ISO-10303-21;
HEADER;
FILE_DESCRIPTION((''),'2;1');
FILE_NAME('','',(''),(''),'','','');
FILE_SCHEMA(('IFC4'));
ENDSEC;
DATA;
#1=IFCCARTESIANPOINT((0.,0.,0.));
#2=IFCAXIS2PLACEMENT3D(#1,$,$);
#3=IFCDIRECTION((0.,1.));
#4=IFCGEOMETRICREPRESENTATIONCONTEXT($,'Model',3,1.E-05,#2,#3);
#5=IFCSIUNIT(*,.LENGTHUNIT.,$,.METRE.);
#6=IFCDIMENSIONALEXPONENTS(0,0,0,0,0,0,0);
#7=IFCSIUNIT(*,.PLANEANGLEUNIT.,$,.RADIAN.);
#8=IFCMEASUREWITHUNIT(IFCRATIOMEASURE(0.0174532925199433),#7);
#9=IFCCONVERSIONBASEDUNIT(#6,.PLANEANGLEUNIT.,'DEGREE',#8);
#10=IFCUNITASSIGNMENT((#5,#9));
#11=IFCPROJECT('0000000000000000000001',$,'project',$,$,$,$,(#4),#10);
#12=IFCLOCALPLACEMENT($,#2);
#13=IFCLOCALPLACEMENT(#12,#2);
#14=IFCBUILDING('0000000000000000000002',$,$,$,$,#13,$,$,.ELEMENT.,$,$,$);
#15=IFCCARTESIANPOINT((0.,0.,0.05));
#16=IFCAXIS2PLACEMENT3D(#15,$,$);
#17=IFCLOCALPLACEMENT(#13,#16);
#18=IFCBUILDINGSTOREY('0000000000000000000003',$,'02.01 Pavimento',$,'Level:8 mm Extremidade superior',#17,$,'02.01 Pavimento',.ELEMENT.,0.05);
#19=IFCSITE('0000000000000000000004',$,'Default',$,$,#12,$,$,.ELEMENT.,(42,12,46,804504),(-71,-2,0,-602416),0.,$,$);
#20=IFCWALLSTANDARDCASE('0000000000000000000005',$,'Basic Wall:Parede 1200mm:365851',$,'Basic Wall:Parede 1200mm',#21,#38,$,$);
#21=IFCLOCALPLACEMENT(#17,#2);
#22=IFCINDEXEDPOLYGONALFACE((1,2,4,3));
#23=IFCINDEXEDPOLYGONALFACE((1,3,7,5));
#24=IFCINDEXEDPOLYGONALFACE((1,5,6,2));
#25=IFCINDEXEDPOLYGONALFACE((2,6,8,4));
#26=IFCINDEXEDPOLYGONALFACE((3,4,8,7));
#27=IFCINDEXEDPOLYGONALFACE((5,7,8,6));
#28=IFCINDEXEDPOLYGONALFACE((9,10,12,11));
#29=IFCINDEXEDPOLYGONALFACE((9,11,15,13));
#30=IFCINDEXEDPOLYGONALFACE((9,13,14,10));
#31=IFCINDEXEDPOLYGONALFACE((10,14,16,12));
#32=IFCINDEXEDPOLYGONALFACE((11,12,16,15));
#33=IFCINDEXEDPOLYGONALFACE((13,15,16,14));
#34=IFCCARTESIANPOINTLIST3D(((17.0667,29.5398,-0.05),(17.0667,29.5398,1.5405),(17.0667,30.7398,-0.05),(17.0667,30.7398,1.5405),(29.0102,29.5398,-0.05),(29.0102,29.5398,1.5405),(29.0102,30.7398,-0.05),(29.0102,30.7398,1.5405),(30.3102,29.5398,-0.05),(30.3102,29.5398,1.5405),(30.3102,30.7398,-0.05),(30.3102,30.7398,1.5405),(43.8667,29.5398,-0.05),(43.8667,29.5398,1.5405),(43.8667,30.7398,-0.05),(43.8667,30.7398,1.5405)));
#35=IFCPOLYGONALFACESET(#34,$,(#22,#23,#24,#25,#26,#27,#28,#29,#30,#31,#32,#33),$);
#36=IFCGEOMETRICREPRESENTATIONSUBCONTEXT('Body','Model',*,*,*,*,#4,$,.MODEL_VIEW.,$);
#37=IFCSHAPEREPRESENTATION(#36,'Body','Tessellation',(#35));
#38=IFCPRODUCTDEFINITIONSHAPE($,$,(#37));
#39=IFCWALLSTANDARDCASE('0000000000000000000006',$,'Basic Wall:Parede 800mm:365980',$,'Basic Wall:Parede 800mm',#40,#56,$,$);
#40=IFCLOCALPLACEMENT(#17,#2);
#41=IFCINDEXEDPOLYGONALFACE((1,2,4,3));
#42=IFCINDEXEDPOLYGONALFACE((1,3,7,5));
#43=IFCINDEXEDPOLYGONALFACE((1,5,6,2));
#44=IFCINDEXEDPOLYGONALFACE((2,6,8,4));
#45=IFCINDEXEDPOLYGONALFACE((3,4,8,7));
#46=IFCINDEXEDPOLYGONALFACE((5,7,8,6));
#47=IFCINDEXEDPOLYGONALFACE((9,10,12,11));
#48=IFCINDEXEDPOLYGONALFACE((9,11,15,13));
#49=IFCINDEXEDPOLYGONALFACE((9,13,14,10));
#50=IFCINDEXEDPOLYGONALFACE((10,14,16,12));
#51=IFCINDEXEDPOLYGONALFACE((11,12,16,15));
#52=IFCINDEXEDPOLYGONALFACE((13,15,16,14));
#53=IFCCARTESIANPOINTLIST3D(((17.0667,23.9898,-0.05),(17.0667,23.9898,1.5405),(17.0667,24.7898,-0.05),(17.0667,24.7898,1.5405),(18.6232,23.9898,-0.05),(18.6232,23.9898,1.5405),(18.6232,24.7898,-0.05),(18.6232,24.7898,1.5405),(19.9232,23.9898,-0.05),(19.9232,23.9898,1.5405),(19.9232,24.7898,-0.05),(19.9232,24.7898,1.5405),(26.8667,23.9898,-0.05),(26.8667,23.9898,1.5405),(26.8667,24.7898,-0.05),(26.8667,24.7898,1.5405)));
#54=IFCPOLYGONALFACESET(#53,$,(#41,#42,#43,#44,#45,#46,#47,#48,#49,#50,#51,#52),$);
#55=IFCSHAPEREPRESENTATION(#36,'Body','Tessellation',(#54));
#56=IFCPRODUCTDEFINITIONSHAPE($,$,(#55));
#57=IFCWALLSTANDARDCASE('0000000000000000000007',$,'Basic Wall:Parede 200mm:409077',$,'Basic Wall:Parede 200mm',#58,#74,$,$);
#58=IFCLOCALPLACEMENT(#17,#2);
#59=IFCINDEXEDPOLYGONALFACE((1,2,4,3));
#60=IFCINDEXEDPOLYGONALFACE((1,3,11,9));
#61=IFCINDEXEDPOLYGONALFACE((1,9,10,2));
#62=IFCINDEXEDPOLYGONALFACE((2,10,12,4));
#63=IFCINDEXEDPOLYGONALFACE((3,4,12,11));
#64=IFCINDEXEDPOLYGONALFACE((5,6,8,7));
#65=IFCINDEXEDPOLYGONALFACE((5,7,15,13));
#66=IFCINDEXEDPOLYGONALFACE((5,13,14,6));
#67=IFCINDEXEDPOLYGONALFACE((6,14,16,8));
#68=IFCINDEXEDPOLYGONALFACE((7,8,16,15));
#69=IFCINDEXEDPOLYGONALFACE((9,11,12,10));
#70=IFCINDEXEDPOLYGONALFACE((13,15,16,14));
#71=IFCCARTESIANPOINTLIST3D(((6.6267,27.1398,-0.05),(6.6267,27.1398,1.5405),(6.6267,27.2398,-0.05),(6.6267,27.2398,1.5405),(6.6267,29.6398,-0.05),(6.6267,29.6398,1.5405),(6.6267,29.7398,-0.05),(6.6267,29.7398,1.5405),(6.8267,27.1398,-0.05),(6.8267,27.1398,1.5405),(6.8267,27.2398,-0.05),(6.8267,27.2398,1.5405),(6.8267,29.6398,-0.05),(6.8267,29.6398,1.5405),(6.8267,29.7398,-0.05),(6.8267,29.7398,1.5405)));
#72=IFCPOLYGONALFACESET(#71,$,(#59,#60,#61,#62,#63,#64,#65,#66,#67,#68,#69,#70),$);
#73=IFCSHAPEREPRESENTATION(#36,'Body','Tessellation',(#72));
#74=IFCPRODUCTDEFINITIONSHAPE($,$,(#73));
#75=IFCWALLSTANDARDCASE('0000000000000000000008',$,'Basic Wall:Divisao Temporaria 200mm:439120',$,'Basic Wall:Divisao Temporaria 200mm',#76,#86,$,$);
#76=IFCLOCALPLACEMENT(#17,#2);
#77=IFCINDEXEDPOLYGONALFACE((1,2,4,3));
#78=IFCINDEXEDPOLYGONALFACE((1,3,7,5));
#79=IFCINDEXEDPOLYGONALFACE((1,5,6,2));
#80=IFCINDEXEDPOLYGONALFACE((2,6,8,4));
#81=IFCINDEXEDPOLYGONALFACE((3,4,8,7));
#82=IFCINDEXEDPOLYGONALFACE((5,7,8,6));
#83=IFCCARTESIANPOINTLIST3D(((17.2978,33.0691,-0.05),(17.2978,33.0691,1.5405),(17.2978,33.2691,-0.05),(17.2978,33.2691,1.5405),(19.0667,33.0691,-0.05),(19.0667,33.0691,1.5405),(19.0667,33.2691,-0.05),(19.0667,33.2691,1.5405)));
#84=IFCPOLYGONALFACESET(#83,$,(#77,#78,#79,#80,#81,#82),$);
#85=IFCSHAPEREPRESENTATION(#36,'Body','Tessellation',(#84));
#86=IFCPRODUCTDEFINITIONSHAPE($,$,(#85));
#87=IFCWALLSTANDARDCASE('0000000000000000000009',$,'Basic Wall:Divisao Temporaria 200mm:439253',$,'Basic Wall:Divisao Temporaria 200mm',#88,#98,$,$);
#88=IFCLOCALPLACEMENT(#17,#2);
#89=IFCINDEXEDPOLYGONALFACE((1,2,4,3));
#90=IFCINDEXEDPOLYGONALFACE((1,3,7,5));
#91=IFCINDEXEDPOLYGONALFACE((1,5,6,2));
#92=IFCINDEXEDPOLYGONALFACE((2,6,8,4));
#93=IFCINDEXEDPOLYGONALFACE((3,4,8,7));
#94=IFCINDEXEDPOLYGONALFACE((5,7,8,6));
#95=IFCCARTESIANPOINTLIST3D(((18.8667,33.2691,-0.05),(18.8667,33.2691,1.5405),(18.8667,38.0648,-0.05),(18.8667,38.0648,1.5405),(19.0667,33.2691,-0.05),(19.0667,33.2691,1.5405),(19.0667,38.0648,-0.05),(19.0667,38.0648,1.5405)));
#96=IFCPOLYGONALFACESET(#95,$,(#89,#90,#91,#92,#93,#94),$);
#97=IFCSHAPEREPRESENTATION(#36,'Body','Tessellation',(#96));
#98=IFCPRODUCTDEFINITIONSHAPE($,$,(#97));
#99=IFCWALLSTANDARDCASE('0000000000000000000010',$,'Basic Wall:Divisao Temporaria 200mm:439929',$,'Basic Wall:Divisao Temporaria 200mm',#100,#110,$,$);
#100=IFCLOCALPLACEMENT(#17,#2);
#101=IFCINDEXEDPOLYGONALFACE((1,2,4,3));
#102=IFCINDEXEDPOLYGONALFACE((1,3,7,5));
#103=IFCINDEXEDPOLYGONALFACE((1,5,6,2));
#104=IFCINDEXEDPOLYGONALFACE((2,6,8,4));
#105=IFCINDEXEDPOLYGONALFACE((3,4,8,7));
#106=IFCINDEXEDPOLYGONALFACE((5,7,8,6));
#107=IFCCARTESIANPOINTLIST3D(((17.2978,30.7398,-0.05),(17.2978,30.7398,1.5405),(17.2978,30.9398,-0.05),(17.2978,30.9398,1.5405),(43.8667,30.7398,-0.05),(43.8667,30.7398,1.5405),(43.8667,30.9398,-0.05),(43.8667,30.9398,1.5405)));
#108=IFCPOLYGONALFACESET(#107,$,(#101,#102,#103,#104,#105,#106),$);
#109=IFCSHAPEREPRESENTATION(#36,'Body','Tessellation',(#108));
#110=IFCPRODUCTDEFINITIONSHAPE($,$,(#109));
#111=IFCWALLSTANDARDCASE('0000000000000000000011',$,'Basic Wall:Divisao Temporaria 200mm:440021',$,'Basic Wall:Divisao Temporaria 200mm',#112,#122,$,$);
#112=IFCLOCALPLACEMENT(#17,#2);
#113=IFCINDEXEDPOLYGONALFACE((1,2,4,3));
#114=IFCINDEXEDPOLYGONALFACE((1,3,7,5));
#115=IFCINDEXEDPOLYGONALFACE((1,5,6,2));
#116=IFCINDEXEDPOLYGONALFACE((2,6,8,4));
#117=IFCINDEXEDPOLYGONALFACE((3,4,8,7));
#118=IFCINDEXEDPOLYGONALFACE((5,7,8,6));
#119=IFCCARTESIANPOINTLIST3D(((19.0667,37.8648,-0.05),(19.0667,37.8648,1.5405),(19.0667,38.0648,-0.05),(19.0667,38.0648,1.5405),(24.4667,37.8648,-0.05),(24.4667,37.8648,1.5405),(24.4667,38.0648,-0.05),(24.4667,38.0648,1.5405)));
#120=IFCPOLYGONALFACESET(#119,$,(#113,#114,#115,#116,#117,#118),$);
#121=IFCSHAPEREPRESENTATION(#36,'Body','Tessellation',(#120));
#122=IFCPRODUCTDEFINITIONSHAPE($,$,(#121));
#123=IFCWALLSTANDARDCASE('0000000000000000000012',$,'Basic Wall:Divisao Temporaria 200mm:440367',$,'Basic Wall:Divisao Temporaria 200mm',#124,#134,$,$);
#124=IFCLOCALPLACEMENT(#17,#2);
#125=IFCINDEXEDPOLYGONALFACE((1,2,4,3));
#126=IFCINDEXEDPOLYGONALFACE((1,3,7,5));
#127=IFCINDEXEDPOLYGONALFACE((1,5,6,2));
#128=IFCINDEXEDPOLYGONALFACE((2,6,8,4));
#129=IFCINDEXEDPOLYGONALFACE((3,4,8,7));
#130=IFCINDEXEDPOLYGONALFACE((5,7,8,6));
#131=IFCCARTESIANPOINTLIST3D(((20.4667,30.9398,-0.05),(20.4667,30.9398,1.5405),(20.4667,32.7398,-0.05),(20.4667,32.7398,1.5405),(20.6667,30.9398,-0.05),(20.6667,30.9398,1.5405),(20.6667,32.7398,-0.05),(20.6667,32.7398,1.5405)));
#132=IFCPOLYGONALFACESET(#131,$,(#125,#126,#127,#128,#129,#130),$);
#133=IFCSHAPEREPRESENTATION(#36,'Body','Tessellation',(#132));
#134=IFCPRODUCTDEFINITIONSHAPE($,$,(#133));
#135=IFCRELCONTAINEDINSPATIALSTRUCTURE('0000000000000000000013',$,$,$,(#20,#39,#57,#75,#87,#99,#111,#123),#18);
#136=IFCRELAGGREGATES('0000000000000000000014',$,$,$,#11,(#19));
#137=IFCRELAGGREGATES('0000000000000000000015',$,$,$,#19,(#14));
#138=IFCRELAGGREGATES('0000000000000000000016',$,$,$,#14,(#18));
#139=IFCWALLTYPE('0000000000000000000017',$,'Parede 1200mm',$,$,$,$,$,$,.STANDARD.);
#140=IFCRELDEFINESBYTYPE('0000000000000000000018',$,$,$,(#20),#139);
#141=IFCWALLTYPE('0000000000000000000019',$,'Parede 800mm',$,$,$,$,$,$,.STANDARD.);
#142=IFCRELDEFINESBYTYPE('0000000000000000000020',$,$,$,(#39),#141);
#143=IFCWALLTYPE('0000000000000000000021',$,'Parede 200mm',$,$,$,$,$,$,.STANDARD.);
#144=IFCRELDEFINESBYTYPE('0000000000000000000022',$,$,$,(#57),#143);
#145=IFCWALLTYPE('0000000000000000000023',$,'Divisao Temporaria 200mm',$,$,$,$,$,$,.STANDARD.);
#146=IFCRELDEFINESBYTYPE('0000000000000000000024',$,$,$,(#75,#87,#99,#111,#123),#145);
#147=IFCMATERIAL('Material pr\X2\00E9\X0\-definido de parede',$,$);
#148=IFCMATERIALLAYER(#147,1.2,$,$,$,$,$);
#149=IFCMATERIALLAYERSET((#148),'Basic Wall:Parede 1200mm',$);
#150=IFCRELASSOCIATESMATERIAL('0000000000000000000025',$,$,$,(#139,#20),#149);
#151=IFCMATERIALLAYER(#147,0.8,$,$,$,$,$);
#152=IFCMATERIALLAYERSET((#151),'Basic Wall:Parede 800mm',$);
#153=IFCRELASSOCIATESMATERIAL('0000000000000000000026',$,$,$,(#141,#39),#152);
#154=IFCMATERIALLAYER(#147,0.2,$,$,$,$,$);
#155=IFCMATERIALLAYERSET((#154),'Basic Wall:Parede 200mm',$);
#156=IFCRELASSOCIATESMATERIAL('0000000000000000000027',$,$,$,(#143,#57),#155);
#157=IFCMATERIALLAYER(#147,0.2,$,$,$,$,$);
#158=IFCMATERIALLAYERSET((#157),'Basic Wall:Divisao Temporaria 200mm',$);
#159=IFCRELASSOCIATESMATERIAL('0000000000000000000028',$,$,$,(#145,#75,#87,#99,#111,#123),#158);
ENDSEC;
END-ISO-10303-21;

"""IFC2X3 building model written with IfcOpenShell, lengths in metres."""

from ifc_helpers import new_model, entity, si_unit, converted_unit, direction, frame, frame_2d, origin, origin_2d_with_axis, place, context, subcontext, project, spatial, rectangle, extrude, clip, halfspace, material, layer, layer_set, layer_usage, type_object, element, save


model = new_model("IFC2X3")

# Units and contexts
model_context = context("Model", 3, precision=1e-05, world=origin(), true_north=direction((0.0, 1.0)))
body_context = subcontext(model_context, "Body", "Model", "MODEL_VIEW")
ifc_project = project(units=[si_unit("LENGTHUNIT", "METRE"), converted_unit("PLANEANGLEUNIT", "DEGREE", entity("IfcRatioMeasure", 0.0174532925199433), si_unit("PLANEANGLEUNIT", "RADIAN"), dimensions=[0, 0, 0, 0, 0, 0, 0])], contexts=[model_context])

# Site, building, storey
site_placement = place(None, origin())
site = spatial("IfcSite", under=ifc_project, at=site_placement, Name="Default", CompositionType="ELEMENT", RefLatitude=(42, 12, 46, 804504), RefLongitude=(-71, -2, 0, -602416), RefElevation=0.0)
building_placement = place(site_placement, origin())
building = spatial("IfcBuilding", under=site, at=building_placement, CompositionType="ELEMENT")
storey_placement = place(building_placement, frame((0.0, 0.0, 0.05)))
storey = spatial("IfcBuildingStorey", under=building, at=storey_placement, Name="02.01 Pavimento", ObjectType="Level:8 mm Extremidade superior", LongName="02.01 Pavimento", CompositionType="ELEMENT", Elevation=0.05)

# Walls, openings
ifc_material_1 = material(Name="Material pré-definido de parede")
ifc_layer_1 = layer(ifc_material_1, 1.2)
ifc_layer_set_1 = layer_set([ifc_layer_1], Name="Basic Wall:Parede 1200mm")
ifc_layer_usage_1 = layer_usage(ifc_layer_set_1, "AXIS2", "POSITIVE", -0.6)
wall_type_1 = type_object("IfcWallType", Name="Parede 1200mm", PredefinedType="STANDARD", material=ifc_layer_set_1)
wall_1_placement = place(storey_placement, frame((17.0667, 30.1398, -0.05)))
wall_1 = element("IfcWallStandardCase", 1, at=wall_1_placement, inside=storey, type_object=wall_type_1, material=ifc_layer_usage_1, Name="Basic Wall:Parede 1200mm:365851", ObjectType="Basic Wall:Parede 1200mm", context=body_context, shape_type="Clipping", body=[
    clip(extrude(rectangle(XDim=26.8, YDim=1.2, at=frame_2d((13.4, 0.0), x_axis=(-1.0, 0.0))), origin(), (0.0, 0.0, 1.0), 1.5905), halfspace(frame((0.0, 0.0, -0.05)), True)),
])
opening_1_placement = place(wall_1_placement, frame((11.9435, -0.924, 0.0)))
element("IfcOpeningElement", 2, at=opening_1_placement, cuts=wall_1, ObjectType="Opening", context=body_context, shape_type="SweptSolid", body=[
    extrude(rectangle(XDim=3.4, YDim=1.3, at=frame_2d((0.0, 0.0), x_axis=(0.0, 1.0))), frame((0.65, 0.0, 1.7), z_axis=(0.0, 1.0, 0.0), x_axis=(-1.0, 0.0, 0.0)), (0.0, 0.0, 1.0), 3.048),
])
ifc_layer_2 = layer(ifc_material_1, 0.8)
ifc_layer_set_2 = layer_set([ifc_layer_2], Name="Basic Wall:Parede 800mm")
ifc_layer_usage_2 = layer_usage(ifc_layer_set_2, "AXIS2", "POSITIVE", -0.4)
wall_type_2 = type_object("IfcWallType", Name="Parede 800mm", PredefinedType="STANDARD", material=ifc_layer_set_2)
wall_2_placement = place(storey_placement, frame((17.0667, 24.3898, -0.05)))
wall_2 = element("IfcWallStandardCase", 3, at=wall_2_placement, inside=storey, type_object=wall_type_2, material=ifc_layer_usage_2, Name="Basic Wall:Parede 800mm:365980", ObjectType="Basic Wall:Parede 800mm", context=body_context, shape_type="Clipping", body=[
    clip(extrude(rectangle(XDim=9.8, YDim=0.8, at=frame_2d((4.9, 0.0), x_axis=(-1.0, 0.0))), origin(), (0.0, 0.0, 1.0), 1.5905), halfspace(frame((0.0, 0.0, -0.05)), True)),
])
opening_2_placement = place(wall_2_placement, frame((1.5565, -1.124, 0.0)))
element("IfcOpeningElement", 4, at=opening_2_placement, cuts=wall_2, ObjectType="Opening", context=body_context, shape_type="SweptSolid", body=[
    extrude(rectangle(XDim=3.4, YDim=1.3, at=frame_2d((0.0, 0.0), x_axis=(0.0, 1.0))), frame((0.65, 0.0, 1.7), z_axis=(0.0, 1.0, 0.0), x_axis=(-1.0, 0.0, 0.0)), (0.0, 0.0, 1.0), 3.048),
])

# Wall, opening
ifc_layer_3 = layer(ifc_material_1, 0.2)
ifc_layer_set_3 = layer_set([ifc_layer_3], Name="Basic Wall:Parede 200mm")
ifc_layer_usage_3 = layer_usage(ifc_layer_set_3, "AXIS2", "NEGATIVE", 0.1)
wall_type_3 = type_object("IfcWallType", Name="Parede 200mm", PredefinedType="STANDARD", material=ifc_layer_set_3)
wall_3_placement = place(storey_placement, frame((6.7267, 29.7398, -0.05), z_axis=(0.0, 0.0, 1.0), x_axis=(0.0, -1.0, 0.0)))
wall_3 = element("IfcWallStandardCase", 5, at=wall_3_placement, inside=storey, type_object=wall_type_3, material=ifc_layer_usage_3, Name="Basic Wall:Parede 200mm:409077", ObjectType="Basic Wall:Parede 200mm", context=body_context, shape_type="Clipping", body=[
    clip(extrude(rectangle(XDim=0.2, YDim=2.6, at=frame_2d((1.3, 0.0), x_axis=(0.0, 1.0))), origin(), (0.0, 0.0, 1.0), 1.5905), halfspace(frame((0.0, 0.0, -0.05)), True)),
])
opening_3_placement = place(wall_3_placement, frame((2.5, -1.624, 0.0), z_axis=(0.0, 0.0, 1.0), x_axis=(0.0, 1.0, 0.0)))
element("IfcOpeningElement", 6, at=opening_3_placement, cuts=wall_3, ObjectType="Opening", context=body_context, shape_type="SweptSolid", body=[
    extrude(rectangle(XDim=4.0, YDim=2.4, at=origin_2d_with_axis()), frame((0.0, 1.2, 2.0), z_axis=(1.0, 0.0, 0.0), x_axis=(0.0, 0.0, 1.0)), (0.0, 0.0, 1.0), 3.048),
])

# Walls
ifc_layer_4 = layer(ifc_material_1, 0.2)
ifc_layer_set_4 = layer_set([ifc_layer_4], Name="Basic Wall:Divisao Temporaria 200mm")
ifc_layer_usage_4 = layer_usage(ifc_layer_set_4, "AXIS2", "NEGATIVE", 0.1)
wall_type_4 = type_object("IfcWallType", Name="Divisao Temporaria 200mm", PredefinedType="STANDARD", material=ifc_layer_set_4)
wall_4_placement = place(storey_placement, frame((17.2978, 33.1691, -0.05)))
element("IfcWallStandardCase", 7, at=wall_4_placement, inside=storey, type_object=wall_type_4, material=ifc_layer_usage_4, Name="Basic Wall:Divisao Temporaria 200mm:439120", ObjectType="Basic Wall:Divisao Temporaria 200mm", context=body_context, shape_type="Clipping", body=[
    clip(extrude(rectangle(XDim=1.7689, YDim=0.2, at=frame_2d((0.8845, 0.0), x_axis=(-1.0, 0.0))), origin(), (0.0, 0.0, 1.0), 1.5905), halfspace(frame((0.0, 0.0, -0.05)), True)),
])
ifc_layer_usage_5 = layer_usage(ifc_layer_set_4, "AXIS2", "NEGATIVE", 0.1)
wall_5_placement = place(storey_placement, frame((18.9667, 33.2691, -0.05), z_axis=(0.0, 0.0, 1.0), x_axis=(0.0, 1.0, 0.0)))
element("IfcWallStandardCase", 8, at=wall_5_placement, inside=storey, type_object=wall_type_4, material=ifc_layer_usage_5, Name="Basic Wall:Divisao Temporaria 200mm:439253", ObjectType="Basic Wall:Divisao Temporaria 200mm", context=body_context, shape_type="Clipping", body=[
    clip(extrude(rectangle(XDim=4.7957, YDim=0.2, at=frame_2d((2.3979, 0.0), x_axis=(-1.0, 0.0))), origin(), (0.0, 0.0, 1.0), 1.5905), halfspace(frame((0.0, 0.0, -0.05)), True)),
])
ifc_layer_usage_6 = layer_usage(ifc_layer_set_4, "AXIS2", "POSITIVE", -0.1)
wall_6_placement = place(storey_placement, frame((17.2978, 30.8398, -0.05)))
element("IfcWallStandardCase", 9, at=wall_6_placement, inside=storey, type_object=wall_type_4, material=ifc_layer_usage_6, Name="Basic Wall:Divisao Temporaria 200mm:439929", ObjectType="Basic Wall:Divisao Temporaria 200mm", context=body_context, shape_type="Clipping", body=[
    clip(extrude(rectangle(XDim=26.5689, YDim=0.2, at=frame_2d((13.2845, 0.0), x_axis=(-1.0, 0.0))), origin(), (0.0, 0.0, 1.0), 1.5905), halfspace(frame((0.0, 0.0, -0.05)), True)),
])
ifc_layer_usage_7 = layer_usage(ifc_layer_set_4, "AXIS2", "NEGATIVE", 0.1)
wall_7_placement = place(storey_placement, frame((19.0667, 37.9648, -0.05)))
element("IfcWallStandardCase", 10, at=wall_7_placement, inside=storey, type_object=wall_type_4, material=ifc_layer_usage_7, Name="Basic Wall:Divisao Temporaria 200mm:440021", ObjectType="Basic Wall:Divisao Temporaria 200mm", context=body_context, shape_type="Clipping", body=[
    clip(extrude(rectangle(XDim=5.4, YDim=0.2, at=frame_2d((2.7, 0.0), x_axis=(-1.0, 0.0))), origin(), (0.0, 0.0, 1.0), 1.5905), halfspace(frame((0.0, 0.0, -0.05)), True)),
])
ifc_layer_usage_8 = layer_usage(ifc_layer_set_4, "AXIS2", "NEGATIVE", 0.1)
wall_8_placement = place(storey_placement, frame((20.5667, 30.9398, -0.05), z_axis=(0.0, 0.0, 1.0), x_axis=(0.0, 1.0, 0.0)))
element("IfcWallStandardCase", 11, at=wall_8_placement, inside=storey, type_object=wall_type_4, material=ifc_layer_usage_8, Name="Basic Wall:Divisao Temporaria 200mm:440367", ObjectType="Basic Wall:Divisao Temporaria 200mm", context=body_context, shape_type="Clipping", body=[
    clip(extrude(rectangle(XDim=1.8, YDim=0.2, at=frame_2d((0.9, 0.0), x_axis=(-1.0, 0.0))), origin(), (0.0, 0.0, 1.0), 1.5905), halfspace(frame((0.0, 0.0, -0.05)), True)),
])

save(model, "model.ifc")
